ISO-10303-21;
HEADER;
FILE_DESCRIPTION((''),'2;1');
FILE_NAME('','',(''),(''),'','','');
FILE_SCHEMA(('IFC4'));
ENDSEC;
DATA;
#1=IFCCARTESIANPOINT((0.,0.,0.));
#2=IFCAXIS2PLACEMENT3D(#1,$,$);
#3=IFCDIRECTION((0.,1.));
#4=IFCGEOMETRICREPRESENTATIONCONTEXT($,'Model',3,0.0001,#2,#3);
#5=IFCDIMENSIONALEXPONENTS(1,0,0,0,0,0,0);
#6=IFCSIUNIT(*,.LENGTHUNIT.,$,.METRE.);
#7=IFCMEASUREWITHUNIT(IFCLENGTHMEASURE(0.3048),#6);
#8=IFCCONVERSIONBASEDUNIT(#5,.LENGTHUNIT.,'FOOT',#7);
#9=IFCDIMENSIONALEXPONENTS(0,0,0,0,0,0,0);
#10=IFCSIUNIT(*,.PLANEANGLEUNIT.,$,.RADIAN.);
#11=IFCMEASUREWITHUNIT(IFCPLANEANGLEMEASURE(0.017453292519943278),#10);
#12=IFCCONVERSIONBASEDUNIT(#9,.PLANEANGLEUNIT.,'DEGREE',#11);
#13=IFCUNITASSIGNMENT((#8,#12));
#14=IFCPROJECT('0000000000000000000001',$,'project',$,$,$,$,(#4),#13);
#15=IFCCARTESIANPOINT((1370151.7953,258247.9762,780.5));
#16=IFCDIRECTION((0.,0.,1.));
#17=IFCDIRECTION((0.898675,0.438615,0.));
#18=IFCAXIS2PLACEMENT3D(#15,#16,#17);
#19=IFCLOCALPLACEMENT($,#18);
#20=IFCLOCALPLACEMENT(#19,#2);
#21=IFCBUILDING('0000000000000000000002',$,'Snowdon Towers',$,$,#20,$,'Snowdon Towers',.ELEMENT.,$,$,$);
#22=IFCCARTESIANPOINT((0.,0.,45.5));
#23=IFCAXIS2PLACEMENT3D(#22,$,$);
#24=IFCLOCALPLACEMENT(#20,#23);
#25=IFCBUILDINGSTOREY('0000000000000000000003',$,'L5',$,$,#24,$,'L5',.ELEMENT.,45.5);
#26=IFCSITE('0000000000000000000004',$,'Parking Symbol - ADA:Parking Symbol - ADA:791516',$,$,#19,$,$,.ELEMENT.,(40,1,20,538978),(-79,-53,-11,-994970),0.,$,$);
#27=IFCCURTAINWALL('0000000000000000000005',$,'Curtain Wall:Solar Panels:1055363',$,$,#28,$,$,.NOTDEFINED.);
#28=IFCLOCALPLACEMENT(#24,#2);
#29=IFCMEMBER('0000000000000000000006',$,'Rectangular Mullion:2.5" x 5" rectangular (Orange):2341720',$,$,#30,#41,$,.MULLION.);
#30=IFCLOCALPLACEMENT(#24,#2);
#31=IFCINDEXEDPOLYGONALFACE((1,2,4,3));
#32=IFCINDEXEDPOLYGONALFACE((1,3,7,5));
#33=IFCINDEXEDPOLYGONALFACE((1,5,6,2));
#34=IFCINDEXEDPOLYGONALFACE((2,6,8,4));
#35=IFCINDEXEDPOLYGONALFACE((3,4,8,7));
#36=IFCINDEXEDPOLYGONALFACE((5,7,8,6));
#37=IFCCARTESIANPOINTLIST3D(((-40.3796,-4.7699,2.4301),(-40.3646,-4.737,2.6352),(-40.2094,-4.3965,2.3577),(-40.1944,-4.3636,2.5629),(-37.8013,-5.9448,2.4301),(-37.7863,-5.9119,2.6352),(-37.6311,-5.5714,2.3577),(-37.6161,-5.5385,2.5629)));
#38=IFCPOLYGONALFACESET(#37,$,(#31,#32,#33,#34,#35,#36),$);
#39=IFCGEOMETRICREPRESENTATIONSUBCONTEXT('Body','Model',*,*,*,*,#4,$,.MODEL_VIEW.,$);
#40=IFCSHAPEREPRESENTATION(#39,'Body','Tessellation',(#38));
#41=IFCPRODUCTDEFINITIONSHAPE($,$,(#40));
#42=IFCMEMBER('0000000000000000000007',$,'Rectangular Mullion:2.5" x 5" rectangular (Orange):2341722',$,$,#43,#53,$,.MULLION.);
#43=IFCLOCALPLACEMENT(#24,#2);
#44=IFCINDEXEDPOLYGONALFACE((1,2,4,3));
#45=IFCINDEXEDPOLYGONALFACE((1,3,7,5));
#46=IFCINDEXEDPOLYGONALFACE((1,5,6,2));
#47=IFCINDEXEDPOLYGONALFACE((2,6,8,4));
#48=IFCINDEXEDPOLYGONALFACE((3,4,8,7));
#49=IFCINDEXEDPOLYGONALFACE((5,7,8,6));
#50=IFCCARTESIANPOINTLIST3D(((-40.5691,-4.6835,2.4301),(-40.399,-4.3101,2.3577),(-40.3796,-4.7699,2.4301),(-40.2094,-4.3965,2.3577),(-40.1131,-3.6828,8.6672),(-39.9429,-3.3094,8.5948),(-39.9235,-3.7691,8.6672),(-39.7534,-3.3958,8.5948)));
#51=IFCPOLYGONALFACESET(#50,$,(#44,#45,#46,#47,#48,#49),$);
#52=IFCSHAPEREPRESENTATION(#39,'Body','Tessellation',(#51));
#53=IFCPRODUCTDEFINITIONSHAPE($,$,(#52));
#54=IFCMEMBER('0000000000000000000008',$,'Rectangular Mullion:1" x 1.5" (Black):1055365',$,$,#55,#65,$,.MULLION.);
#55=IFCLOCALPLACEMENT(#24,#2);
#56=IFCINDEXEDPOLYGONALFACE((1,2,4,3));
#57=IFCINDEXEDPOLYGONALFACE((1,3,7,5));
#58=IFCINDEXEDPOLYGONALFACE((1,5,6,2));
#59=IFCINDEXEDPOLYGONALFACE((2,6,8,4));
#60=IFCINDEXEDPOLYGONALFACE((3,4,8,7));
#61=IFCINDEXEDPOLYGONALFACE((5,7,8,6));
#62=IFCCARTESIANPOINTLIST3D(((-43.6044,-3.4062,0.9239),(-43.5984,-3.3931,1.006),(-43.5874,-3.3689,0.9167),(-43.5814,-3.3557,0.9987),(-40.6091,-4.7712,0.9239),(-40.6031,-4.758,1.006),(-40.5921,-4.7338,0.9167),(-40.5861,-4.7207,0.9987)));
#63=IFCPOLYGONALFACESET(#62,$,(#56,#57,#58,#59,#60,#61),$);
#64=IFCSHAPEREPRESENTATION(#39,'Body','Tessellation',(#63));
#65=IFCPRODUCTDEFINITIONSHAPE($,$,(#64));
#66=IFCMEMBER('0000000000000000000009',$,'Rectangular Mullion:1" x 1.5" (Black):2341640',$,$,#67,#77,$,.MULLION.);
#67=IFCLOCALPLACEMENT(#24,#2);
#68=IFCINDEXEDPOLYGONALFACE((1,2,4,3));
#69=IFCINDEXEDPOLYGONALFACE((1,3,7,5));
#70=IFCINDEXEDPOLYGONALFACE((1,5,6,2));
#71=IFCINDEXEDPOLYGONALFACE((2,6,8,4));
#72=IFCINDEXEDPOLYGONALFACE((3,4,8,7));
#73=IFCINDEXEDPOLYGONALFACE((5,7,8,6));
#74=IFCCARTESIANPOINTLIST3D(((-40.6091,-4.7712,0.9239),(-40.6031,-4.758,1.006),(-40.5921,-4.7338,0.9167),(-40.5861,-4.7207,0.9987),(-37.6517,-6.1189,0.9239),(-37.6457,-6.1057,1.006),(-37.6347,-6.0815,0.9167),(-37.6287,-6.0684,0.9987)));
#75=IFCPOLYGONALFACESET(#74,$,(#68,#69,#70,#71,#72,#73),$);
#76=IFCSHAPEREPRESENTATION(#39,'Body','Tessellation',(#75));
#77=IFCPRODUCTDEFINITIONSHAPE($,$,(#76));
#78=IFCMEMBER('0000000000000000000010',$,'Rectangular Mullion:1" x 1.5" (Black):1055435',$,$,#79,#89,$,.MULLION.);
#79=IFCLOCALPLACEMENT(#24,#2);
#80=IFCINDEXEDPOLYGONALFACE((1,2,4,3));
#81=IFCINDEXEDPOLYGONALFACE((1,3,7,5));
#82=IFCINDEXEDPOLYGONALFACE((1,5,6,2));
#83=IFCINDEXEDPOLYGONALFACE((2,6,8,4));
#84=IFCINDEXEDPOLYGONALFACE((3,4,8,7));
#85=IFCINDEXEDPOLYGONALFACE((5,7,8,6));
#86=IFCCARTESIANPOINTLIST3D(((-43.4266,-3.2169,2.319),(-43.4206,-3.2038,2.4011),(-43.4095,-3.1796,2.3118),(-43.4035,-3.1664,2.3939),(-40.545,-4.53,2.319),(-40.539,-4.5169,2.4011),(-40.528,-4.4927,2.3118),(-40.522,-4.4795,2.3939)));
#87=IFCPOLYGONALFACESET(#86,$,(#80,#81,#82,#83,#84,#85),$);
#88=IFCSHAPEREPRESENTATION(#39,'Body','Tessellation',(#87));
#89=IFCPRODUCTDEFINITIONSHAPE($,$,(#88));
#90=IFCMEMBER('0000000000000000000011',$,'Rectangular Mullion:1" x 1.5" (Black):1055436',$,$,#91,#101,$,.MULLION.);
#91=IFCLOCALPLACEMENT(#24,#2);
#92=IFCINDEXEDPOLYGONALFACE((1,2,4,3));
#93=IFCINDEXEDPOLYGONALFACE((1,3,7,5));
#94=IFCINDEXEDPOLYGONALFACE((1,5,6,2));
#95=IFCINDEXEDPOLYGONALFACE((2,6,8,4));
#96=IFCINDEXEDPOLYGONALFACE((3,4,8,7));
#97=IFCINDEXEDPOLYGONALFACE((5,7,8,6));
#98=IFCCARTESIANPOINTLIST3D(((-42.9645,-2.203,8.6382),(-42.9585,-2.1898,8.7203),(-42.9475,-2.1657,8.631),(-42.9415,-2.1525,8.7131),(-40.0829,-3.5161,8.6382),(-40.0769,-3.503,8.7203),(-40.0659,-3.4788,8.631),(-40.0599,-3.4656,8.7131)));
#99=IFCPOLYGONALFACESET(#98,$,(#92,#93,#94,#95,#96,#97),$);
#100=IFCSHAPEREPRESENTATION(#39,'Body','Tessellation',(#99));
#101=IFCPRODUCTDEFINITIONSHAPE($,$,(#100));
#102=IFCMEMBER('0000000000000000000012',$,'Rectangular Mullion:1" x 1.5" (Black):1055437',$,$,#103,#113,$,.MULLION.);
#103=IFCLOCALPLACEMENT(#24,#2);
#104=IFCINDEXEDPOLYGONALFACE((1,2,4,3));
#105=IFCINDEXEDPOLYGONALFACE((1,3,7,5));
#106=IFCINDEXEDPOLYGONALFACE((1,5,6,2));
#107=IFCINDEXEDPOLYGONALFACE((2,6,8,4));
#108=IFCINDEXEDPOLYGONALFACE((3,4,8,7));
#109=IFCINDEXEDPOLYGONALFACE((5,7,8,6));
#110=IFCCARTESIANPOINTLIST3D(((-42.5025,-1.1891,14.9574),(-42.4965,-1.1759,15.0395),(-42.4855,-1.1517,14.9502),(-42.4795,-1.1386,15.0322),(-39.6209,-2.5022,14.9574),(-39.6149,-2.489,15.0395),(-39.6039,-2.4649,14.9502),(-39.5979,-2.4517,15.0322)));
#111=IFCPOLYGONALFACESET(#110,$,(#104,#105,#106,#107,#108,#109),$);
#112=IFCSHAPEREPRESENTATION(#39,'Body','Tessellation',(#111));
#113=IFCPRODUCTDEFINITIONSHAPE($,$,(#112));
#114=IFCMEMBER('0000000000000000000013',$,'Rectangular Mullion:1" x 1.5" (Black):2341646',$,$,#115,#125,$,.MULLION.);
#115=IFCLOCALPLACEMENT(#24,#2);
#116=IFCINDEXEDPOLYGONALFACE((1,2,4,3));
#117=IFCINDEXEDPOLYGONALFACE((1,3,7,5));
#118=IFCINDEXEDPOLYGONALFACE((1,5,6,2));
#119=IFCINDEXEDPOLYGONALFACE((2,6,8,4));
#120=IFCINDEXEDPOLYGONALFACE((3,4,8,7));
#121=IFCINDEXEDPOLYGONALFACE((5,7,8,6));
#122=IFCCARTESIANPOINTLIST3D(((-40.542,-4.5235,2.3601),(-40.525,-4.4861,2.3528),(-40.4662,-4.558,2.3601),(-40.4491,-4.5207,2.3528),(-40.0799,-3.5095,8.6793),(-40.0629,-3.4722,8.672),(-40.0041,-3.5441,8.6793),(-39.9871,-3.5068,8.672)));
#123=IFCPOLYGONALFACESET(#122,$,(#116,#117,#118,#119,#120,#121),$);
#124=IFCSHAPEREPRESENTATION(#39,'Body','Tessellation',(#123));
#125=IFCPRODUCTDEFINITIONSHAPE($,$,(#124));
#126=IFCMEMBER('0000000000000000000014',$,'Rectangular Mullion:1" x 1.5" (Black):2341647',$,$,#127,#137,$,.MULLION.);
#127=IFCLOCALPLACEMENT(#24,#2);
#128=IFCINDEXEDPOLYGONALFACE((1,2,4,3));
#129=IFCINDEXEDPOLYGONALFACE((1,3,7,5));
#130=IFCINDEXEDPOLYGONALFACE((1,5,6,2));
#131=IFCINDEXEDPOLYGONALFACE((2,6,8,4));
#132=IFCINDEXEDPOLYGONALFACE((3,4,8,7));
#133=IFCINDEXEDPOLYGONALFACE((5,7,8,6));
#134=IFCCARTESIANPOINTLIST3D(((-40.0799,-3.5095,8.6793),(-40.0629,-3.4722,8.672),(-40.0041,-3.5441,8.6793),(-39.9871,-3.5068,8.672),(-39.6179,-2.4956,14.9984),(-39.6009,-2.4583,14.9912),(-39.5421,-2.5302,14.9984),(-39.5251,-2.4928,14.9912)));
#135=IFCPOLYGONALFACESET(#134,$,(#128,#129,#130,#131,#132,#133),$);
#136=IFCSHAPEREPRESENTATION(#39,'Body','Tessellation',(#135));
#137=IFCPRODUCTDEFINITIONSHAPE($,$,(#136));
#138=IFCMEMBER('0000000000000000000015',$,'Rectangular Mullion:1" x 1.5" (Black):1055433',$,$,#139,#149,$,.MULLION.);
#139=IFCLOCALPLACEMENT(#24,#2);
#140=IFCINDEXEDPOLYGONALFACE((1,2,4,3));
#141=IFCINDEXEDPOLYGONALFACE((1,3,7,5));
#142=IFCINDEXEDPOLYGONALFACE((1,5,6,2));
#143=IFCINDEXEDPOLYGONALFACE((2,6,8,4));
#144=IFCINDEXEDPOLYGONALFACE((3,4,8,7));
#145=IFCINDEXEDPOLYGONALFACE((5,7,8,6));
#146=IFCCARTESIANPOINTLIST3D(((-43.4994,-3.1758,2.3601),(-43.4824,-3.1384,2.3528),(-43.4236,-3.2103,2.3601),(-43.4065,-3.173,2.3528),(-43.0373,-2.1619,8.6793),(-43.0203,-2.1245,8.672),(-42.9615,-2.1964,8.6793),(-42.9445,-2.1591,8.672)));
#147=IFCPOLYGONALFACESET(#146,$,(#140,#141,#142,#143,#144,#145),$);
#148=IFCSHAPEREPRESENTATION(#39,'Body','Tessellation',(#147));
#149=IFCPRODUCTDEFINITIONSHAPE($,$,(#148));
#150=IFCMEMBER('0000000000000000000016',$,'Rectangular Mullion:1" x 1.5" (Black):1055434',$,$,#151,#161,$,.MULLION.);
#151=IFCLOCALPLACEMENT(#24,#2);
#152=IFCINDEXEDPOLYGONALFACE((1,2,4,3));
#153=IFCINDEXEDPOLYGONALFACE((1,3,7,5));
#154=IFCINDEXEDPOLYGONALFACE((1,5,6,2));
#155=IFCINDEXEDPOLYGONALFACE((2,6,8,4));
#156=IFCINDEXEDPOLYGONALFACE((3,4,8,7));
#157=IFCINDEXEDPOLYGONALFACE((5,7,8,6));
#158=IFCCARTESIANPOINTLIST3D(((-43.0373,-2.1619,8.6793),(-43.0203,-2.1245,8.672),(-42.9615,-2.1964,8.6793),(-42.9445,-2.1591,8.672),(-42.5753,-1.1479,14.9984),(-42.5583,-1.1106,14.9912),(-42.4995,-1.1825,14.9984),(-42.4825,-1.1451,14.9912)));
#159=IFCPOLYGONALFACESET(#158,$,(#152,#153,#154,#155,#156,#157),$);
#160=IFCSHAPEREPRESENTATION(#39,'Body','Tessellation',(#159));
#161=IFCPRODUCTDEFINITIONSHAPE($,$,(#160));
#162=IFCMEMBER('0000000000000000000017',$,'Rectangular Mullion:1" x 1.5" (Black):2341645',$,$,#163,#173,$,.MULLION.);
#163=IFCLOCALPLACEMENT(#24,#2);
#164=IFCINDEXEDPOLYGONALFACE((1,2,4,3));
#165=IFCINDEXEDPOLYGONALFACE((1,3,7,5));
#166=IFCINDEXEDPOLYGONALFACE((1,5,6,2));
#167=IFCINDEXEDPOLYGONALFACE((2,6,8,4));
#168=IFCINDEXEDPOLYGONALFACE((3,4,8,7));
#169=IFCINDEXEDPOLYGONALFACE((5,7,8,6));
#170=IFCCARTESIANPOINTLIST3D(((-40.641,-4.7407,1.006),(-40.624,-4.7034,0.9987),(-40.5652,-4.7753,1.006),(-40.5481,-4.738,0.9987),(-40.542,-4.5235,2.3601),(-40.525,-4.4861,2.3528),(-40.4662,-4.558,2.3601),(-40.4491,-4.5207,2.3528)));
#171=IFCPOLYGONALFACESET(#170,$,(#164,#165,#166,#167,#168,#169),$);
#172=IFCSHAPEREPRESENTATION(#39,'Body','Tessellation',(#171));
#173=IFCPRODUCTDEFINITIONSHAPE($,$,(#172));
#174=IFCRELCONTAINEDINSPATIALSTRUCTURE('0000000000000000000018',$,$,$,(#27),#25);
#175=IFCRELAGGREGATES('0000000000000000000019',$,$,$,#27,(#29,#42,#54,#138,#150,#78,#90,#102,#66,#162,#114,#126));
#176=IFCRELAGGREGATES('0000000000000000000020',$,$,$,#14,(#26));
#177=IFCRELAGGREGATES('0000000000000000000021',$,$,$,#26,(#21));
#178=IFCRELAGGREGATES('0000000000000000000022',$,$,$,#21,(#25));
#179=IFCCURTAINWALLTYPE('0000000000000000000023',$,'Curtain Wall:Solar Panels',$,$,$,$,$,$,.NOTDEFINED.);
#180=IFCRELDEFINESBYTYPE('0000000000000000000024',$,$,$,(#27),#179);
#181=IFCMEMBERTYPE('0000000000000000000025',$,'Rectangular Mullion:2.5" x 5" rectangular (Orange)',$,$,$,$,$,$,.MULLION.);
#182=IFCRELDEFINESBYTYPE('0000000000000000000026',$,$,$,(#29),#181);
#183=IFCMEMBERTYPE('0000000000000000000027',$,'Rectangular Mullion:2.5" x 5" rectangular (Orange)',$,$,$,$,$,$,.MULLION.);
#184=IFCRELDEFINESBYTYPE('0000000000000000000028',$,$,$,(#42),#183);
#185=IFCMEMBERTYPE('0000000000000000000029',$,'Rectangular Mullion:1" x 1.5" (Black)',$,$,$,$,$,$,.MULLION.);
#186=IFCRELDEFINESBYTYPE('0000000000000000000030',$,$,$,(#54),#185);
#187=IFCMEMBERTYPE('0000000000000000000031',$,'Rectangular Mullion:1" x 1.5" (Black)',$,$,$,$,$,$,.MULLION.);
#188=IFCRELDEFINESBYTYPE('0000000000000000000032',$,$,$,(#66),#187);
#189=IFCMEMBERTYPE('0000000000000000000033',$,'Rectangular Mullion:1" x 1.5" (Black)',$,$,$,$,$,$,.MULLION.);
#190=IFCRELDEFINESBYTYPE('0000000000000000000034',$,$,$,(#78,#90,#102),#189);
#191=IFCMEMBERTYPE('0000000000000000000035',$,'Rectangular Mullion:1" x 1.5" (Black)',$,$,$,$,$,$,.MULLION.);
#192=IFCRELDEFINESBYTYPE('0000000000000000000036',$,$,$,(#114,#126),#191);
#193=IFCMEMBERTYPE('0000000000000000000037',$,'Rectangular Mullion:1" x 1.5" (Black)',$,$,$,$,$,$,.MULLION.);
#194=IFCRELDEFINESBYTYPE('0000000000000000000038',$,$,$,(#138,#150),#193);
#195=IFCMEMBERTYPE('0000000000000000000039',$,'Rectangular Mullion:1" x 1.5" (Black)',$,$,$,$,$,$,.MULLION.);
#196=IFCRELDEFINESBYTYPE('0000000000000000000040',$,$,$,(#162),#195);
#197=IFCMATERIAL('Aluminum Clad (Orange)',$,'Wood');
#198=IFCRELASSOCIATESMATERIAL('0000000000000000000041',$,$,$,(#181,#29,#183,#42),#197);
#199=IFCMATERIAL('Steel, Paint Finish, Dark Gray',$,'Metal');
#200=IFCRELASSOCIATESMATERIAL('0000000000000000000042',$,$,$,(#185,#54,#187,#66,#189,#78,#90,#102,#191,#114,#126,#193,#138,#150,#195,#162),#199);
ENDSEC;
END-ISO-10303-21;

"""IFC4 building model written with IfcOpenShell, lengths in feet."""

from ifc_helpers import new_model, entity, si_unit, converted_unit, direction, frame, origin, place, context, subcontext, project, spatial, indexed_curve, outline, extrude, source, transform, mapped, material, type_object, type_shapes, element, aggregate, save


model = new_model("IFC4")

# Units and contexts
model_context = context("Model", 3, precision=0.0001, world=origin(), true_north=direction((0.0, 1.0)))
body_context = subcontext(model_context, "Body", "Model", "MODEL_VIEW")
ifc_project = project(units=[converted_unit("LENGTHUNIT", "FOOT", entity("IfcLengthMeasure", 0.3048), si_unit("LENGTHUNIT", "METRE"), dimensions=[1, 0, 0, 0, 0, 0, 0]), converted_unit("PLANEANGLEUNIT", "DEGREE", entity("IfcPlaneAngleMeasure", 0.017453292519943278), si_unit("PLANEANGLEUNIT", "RADIAN"), dimensions=[0, 0, 0, 0, 0, 0, 0])], contexts=[model_context])

# Site, building, storey
site_placement = place(None, frame((1370151.7953, 258247.9762, 780.5), z_axis=(0.0, 0.0, 1.0), x_axis=(0.898675, 0.438615, 0.0)))
site = spatial("IfcSite", under=ifc_project, at=site_placement, Name="Parking Symbol - ADA:Parking Symbol - ADA:791516", CompositionType="ELEMENT", RefLatitude=(40, 1, 20, 538978), RefLongitude=(-79, -53, -11, -994970), RefElevation=0.0)
building_placement = place(site_placement, origin())
building = spatial("IfcBuilding", under=site, at=building_placement, Name="Snowdon Towers", LongName="Snowdon Towers", CompositionType="ELEMENT")
storey_placement = place(building_placement, frame((0.0, 0.0, 45.5)))
storey = spatial("IfcBuildingStorey", under=building, at=storey_placement, Name="L5", LongName="L5", CompositionType="ELEMENT", Elevation=45.5)

# Curtain wall, members
curtain_wall_type = type_object("IfcCurtainWallType", Name="Curtain Wall:Solar Panels", PredefinedType="NOTDEFINED")
curtain_wall_placement = place(storey_placement, frame((0.0, 0.0, -45.5)))
curtain_wall = element("IfcCurtainWall", 1, at=curtain_wall_placement, inside=storey, type_object=curtain_wall_type, Name="Curtain Wall:Solar Panels:1055363", PredefinedType="NOTDEFINED")
ifc_material_1 = material(Name="Aluminum Clad (Orange)", Category="Wood")
member_type_1 = type_object("IfcMemberType", Name="Rectangular Mullion:2.5\" x 5\" rectangular (Orange)", PredefinedType="MULLION", material=ifc_material_1)
shared_shape_1 = source(origin(), body_context, "Body", "SweptSolid", [
    extrude(outline(indexed_curve([(-0.1042, -0.2083), (0.1042, -0.2083), (0.1042, 0.2083), (-0.1042, 0.2083), (-0.1042, -0.2083)], self_intersect=False)), frame((-0.1042, 0.0, -2.8333), z_axis=(0.0, 0.0, 1.0), x_axis=(-1.0, 0.0, 0.0)), (0.0, 0.0, 1.0), 2.8333),
])
type_shapes(member_type_1, [shared_shape_1])
member_1_placement = place(curtain_wall_placement, frame((-40.2945, -4.5832, 47.8939), z_axis=(-0.909972, 0.414671, 0.0), x_axis=(-0.072007, -0.158015, -0.984808)))
member_1 = element("IfcMember", 2, at=member_1_placement, type_object=member_type_1, material=ifc_material_1, Name="Rectangular Mullion:2.5\" x 5\" rectangular (Orange):2341720", PredefinedType="MULLION", context=body_context, shape_type="MappedRepresentation", body=[
    mapped(shared_shape_1, transform((0.0, 0.0, 0.0), scale=1.0)),
])
member_type_2 = type_object("IfcMemberType", Name="Rectangular Mullion:2.5\" x 5\" rectangular (Orange)", PredefinedType="MULLION", material=ifc_material_1)
shared_shape_2 = source(origin(), body_context, "Body", "SweptSolid", [
    extrude(outline(indexed_curve([(-0.1042, -0.2083), (0.1042, -0.2083), (0.1042, 0.2083), (-0.1042, 0.2083), (-0.1042, -0.2083)], self_intersect=False)), frame((-0.1042, 0.0, -6.3333), z_axis=(0.0, 0.0, 1.0), x_axis=(-1.0, 0.0, 0.0)), (0.0, 0.0, 1.0), 6.3333),
])
type_shapes(member_type_2, [shared_shape_2])
member_2_placement = place(curtain_wall_placement, frame((-40.028, -3.4961, 54.131), z_axis=(0.072007, 0.158015, 0.984808), x_axis=(-0.909972, 0.414671, 0.0)))
member_2 = element("IfcMember", 3, at=member_2_placement, type_object=member_type_2, material=ifc_material_1, Name="Rectangular Mullion:2.5\" x 5\" rectangular (Orange):2341722", PredefinedType="MULLION", context=body_context, shape_type="MappedRepresentation", body=[
    mapped(shared_shape_2, transform((0.0, 0.0, 0.0), scale=1.0)),
])
ifc_material_2 = material(Name="Steel, Paint Finish, Dark Gray", Category="Metal")
member_type_3 = type_object("IfcMemberType", Name="Rectangular Mullion:1\" x 1.5\" (Black)", PredefinedType="MULLION", material=ifc_material_2)
shared_shape_3 = source(origin(), body_context, "Body", "SweptSolid", [
    extrude(outline(indexed_curve([(-0.0417, -0.0208), (0.0417, -0.0208), (0.0417, 0.0208), (-0.0417, 0.0208), (-0.0417, -0.0208)], self_intersect=False)), frame((-0.0417, 0.0208, -3.2917), z_axis=(0.0, 0.0, 1.0), x_axis=(-1.0, 0.0, 0.0)), (0.0, 0.0, 1.0), 3.2917),
])
type_shapes(member_type_3, [shared_shape_3])
member_3_placement = place(curtain_wall_placement, frame((-43.5874, -3.3689, 46.4167), z_axis=(-0.909972, 0.414671, 0.0), x_axis=(-0.072007, -0.158015, -0.984808)))
member_3 = element("IfcMember", 4, at=member_3_placement, type_object=member_type_3, material=ifc_material_2, Name="Rectangular Mullion:1\" x 1.5\" (Black):1055365", PredefinedType="MULLION", context=body_context, shape_type="MappedRepresentation", body=[
    mapped(shared_shape_3, transform((0.0, 0.0, 0.0), scale=1.0)),
])
member_type_4 = type_object("IfcMemberType", Name="Rectangular Mullion:1\" x 1.5\" (Black)", PredefinedType="MULLION", material=ifc_material_2)
shared_shape_4 = source(origin(), body_context, "Body", "SweptSolid", [
    extrude(outline(indexed_curve([(-0.0417, -0.0208), (0.0417, -0.0208), (0.0417, 0.0208), (-0.0417, 0.0208), (-0.0417, -0.0208)], self_intersect=False)), frame((-0.0417, 0.0208, -3.25), z_axis=(0.0, 0.0, 1.0), x_axis=(-1.0, 0.0, 0.0)), (0.0, 0.0, 1.0), 3.25),
])
type_shapes(member_type_4, [shared_shape_4])
member_4_placement = place(curtain_wall_placement, frame((-40.5921, -4.7338, 46.4167), z_axis=(-0.909972, 0.414671, 0.0), x_axis=(-0.072007, -0.158015, -0.984808)))
member_4 = element("IfcMember", 5, at=member_4_placement, type_object=member_type_4, material=ifc_material_2, Name="Rectangular Mullion:1\" x 1.5\" (Black):2341640", PredefinedType="MULLION", context=body_context, shape_type="MappedRepresentation", body=[
    mapped(shared_shape_4, transform((0.0, 0.0, 0.0), scale=1.0)),
])
member_type_5 = type_object("IfcMemberType", Name="Rectangular Mullion:1\" x 1.5\" (Black)", PredefinedType="MULLION", material=ifc_material_2)
shared_shape_5 = source(origin(), body_context, "Body", "SweptSolid", [
    extrude(outline(indexed_curve([(-0.0417, -0.0208), (0.0417, -0.0208), (0.0417, 0.0208), (-0.0417, 0.0208), (-0.0417, -0.0208)], self_intersect=False)), frame((0.0, 0.0208, -3.1667), z_axis=(0.0, 0.0, 1.0), x_axis=(-1.0, 0.0, 0.0)), (0.0, 0.0, 1.0), 3.1667),
])
type_shapes(member_type_5, [shared_shape_5])
member_5_placement = place(curtain_wall_placement, frame((-40.525, -4.4861, 47.8528), z_axis=(0.909972, -0.414671, 0.0), x_axis=(0.072007, 0.158015, 0.984808)))
member_5 = element("IfcMember", 6, at=member_5_placement, type_object=member_type_5, material=ifc_material_2, Name="Rectangular Mullion:1\" x 1.5\" (Black):1055435", PredefinedType="MULLION", context=body_context, shape_type="MappedRepresentation", body=[
    mapped(shared_shape_5, transform((0.0, 0.0, 0.0), scale=1.0)),
])
member_6_placement = place(curtain_wall_placement, frame((-40.0629, -3.4722, 54.172), z_axis=(0.909972, -0.414671, 0.0), x_axis=(0.072007, 0.158015, 0.984808)))
member_6 = element("IfcMember", 7, at=member_6_placement, type_object=member_type_5, material=ifc_material_2, Name="Rectangular Mullion:1\" x 1.5\" (Black):1055436", PredefinedType="MULLION", context=body_context, shape_type="MappedRepresentation", body=[
    mapped(shared_shape_5, transform((0.0, 0.0, 0.0), scale=1.0)),
])
member_7_placement = place(curtain_wall_placement, frame((-39.6009, -2.4583, 60.4912), z_axis=(0.909972, -0.414671, 0.0), x_axis=(0.072007, 0.158015, 0.984808)))
member_7 = element("IfcMember", 8, at=member_7_placement, type_object=member_type_5, material=ifc_material_2, Name="Rectangular Mullion:1\" x 1.5\" (Black):1055437", PredefinedType="MULLION", context=body_context, shape_type="MappedRepresentation", body=[
    mapped(shared_shape_5, transform((0.0, 0.0, 0.0), scale=1.0)),
])
member_type_6 = type_object("IfcMemberType", Name="Rectangular Mullion:1\" x 1.5\" (Black)", PredefinedType="MULLION", material=ifc_material_2)
shared_shape_6 = source(origin(), body_context, "Body", "SweptSolid", [
    extrude(outline(indexed_curve([(-0.0417, -0.0208), (0.0417, -0.0208), (0.0417, 0.0208), (-0.0417, 0.0208), (-0.0417, -0.0208)], self_intersect=False)), frame((0.0, 0.0208, -6.4167), z_axis=(0.0, 0.0, 1.0), x_axis=(-1.0, 0.0, 0.0)), (0.0, 0.0, 1.0), 6.4167),
])
type_shapes(member_type_6, [shared_shape_6])
member_8_placement = place(curtain_wall_placement, frame((-40.4871, -4.5034, 47.8528), z_axis=(-0.072007, -0.158015, -0.984808), x_axis=(0.909972, -0.414671, 0.0)))
member_8 = element("IfcMember", 9, at=member_8_placement, type_object=member_type_6, material=ifc_material_2, Name="Rectangular Mullion:1\" x 1.5\" (Black):2341646", PredefinedType="MULLION", context=body_context, shape_type="MappedRepresentation", body=[
    mapped(shared_shape_6, transform((0.0, 0.0, 0.0), scale=1.0)),
])
member_9_placement = place(curtain_wall_placement, frame((-40.025, -3.4895, 54.172), z_axis=(-0.072007, -0.158015, -0.984808), x_axis=(0.909972, -0.414671, 0.0)))
member_9 = element("IfcMember", 10, at=member_9_placement, type_object=member_type_6, material=ifc_material_2, Name="Rectangular Mullion:1\" x 1.5\" (Black):2341647", PredefinedType="MULLION", context=body_context, shape_type="MappedRepresentation", body=[
    mapped(shared_shape_6, transform((0.0, 0.0, 0.0), scale=1.0)),
])
member_type_7 = type_object("IfcMemberType", Name="Rectangular Mullion:1\" x 1.5\" (Black)", PredefinedType="MULLION", material=ifc_material_2)
shared_shape_7 = source(origin(), body_context, "Body", "SweptSolid", [
    extrude(outline(indexed_curve([(-0.0417, -0.0208), (0.0417, -0.0208), (0.0417, 0.0208), (-0.0417, 0.0208), (-0.0417, -0.0208)], self_intersect=False)), frame((-0.0417, 0.0208, -6.4167), z_axis=(0.0, 0.0, 1.0), x_axis=(-1.0, 0.0, 0.0)), (0.0, 0.0, 1.0), 6.4167),
])
type_shapes(member_type_7, [shared_shape_7])
member_10_placement = place(curtain_wall_placement, frame((-43.0203, -2.1245, 54.172), z_axis=(0.072007, 0.158015, 0.984808), x_axis=(-0.909972, 0.414671, 0.0)))
member_10 = element("IfcMember", 11, at=member_10_placement, type_object=member_type_7, material=ifc_material_2, Name="Rectangular Mullion:1\" x 1.5\" (Black):1055433", PredefinedType="MULLION", context=body_context, shape_type="MappedRepresentation", body=[
    mapped(shared_shape_7, transform((0.0, 0.0, 0.0), scale=1.0)),
])
member_11_placement = place(curtain_wall_placement, frame((-42.5583, -1.1106, 60.4912), z_axis=(0.072007, 0.158015, 0.984808), x_axis=(-0.909972, 0.414671, 0.0)))
member_11 = element("IfcMember", 12, at=member_11_placement, type_object=member_type_7, material=ifc_material_2, Name="Rectangular Mullion:1\" x 1.5\" (Black):1055434", PredefinedType="MULLION", context=body_context, shape_type="MappedRepresentation", body=[
    mapped(shared_shape_7, transform((0.0, 0.0, 0.0), scale=1.0)),
])
member_type_8 = type_object("IfcMemberType", Name="Rectangular Mullion:1\" x 1.5\" (Black)", PredefinedType="MULLION", material=ifc_material_2)
shared_shape_8 = source(origin(), body_context, "Body", "SweptSolid", [
    extrude(outline(indexed_curve([(-0.0417, -0.0208), (0.0417, -0.0208), (0.0417, 0.0208), (-0.0417, 0.0208), (-0.0417, -0.0208)], self_intersect=False)), frame((0.0, 0.0208, -1.375), z_axis=(0.0, 0.0, 1.0), x_axis=(-1.0, 0.0, 0.0)), (0.0, 0.0, 1.0), 1.375),
])
type_shapes(member_type_8, [shared_shape_8])
member_12_placement = place(curtain_wall_placement, frame((-40.5861, -4.7207, 46.4987), z_axis=(-0.072007, -0.158015, -0.984808), x_axis=(0.909972, -0.414671, 0.0)))
member_12 = element("IfcMember", 13, at=member_12_placement, type_object=member_type_8, material=ifc_material_2, Name="Rectangular Mullion:1\" x 1.5\" (Black):2341645", PredefinedType="MULLION", context=body_context, shape_type="MappedRepresentation", body=[
    mapped(shared_shape_8, transform((0.0, 0.0, 0.0), scale=1.0)),
])
aggregate(curtain_wall, [member_1, member_2, member_3, member_10, member_11, member_5, member_6, member_7, member_4, member_12, member_8, member_9])

save(model, "model.ifc")
